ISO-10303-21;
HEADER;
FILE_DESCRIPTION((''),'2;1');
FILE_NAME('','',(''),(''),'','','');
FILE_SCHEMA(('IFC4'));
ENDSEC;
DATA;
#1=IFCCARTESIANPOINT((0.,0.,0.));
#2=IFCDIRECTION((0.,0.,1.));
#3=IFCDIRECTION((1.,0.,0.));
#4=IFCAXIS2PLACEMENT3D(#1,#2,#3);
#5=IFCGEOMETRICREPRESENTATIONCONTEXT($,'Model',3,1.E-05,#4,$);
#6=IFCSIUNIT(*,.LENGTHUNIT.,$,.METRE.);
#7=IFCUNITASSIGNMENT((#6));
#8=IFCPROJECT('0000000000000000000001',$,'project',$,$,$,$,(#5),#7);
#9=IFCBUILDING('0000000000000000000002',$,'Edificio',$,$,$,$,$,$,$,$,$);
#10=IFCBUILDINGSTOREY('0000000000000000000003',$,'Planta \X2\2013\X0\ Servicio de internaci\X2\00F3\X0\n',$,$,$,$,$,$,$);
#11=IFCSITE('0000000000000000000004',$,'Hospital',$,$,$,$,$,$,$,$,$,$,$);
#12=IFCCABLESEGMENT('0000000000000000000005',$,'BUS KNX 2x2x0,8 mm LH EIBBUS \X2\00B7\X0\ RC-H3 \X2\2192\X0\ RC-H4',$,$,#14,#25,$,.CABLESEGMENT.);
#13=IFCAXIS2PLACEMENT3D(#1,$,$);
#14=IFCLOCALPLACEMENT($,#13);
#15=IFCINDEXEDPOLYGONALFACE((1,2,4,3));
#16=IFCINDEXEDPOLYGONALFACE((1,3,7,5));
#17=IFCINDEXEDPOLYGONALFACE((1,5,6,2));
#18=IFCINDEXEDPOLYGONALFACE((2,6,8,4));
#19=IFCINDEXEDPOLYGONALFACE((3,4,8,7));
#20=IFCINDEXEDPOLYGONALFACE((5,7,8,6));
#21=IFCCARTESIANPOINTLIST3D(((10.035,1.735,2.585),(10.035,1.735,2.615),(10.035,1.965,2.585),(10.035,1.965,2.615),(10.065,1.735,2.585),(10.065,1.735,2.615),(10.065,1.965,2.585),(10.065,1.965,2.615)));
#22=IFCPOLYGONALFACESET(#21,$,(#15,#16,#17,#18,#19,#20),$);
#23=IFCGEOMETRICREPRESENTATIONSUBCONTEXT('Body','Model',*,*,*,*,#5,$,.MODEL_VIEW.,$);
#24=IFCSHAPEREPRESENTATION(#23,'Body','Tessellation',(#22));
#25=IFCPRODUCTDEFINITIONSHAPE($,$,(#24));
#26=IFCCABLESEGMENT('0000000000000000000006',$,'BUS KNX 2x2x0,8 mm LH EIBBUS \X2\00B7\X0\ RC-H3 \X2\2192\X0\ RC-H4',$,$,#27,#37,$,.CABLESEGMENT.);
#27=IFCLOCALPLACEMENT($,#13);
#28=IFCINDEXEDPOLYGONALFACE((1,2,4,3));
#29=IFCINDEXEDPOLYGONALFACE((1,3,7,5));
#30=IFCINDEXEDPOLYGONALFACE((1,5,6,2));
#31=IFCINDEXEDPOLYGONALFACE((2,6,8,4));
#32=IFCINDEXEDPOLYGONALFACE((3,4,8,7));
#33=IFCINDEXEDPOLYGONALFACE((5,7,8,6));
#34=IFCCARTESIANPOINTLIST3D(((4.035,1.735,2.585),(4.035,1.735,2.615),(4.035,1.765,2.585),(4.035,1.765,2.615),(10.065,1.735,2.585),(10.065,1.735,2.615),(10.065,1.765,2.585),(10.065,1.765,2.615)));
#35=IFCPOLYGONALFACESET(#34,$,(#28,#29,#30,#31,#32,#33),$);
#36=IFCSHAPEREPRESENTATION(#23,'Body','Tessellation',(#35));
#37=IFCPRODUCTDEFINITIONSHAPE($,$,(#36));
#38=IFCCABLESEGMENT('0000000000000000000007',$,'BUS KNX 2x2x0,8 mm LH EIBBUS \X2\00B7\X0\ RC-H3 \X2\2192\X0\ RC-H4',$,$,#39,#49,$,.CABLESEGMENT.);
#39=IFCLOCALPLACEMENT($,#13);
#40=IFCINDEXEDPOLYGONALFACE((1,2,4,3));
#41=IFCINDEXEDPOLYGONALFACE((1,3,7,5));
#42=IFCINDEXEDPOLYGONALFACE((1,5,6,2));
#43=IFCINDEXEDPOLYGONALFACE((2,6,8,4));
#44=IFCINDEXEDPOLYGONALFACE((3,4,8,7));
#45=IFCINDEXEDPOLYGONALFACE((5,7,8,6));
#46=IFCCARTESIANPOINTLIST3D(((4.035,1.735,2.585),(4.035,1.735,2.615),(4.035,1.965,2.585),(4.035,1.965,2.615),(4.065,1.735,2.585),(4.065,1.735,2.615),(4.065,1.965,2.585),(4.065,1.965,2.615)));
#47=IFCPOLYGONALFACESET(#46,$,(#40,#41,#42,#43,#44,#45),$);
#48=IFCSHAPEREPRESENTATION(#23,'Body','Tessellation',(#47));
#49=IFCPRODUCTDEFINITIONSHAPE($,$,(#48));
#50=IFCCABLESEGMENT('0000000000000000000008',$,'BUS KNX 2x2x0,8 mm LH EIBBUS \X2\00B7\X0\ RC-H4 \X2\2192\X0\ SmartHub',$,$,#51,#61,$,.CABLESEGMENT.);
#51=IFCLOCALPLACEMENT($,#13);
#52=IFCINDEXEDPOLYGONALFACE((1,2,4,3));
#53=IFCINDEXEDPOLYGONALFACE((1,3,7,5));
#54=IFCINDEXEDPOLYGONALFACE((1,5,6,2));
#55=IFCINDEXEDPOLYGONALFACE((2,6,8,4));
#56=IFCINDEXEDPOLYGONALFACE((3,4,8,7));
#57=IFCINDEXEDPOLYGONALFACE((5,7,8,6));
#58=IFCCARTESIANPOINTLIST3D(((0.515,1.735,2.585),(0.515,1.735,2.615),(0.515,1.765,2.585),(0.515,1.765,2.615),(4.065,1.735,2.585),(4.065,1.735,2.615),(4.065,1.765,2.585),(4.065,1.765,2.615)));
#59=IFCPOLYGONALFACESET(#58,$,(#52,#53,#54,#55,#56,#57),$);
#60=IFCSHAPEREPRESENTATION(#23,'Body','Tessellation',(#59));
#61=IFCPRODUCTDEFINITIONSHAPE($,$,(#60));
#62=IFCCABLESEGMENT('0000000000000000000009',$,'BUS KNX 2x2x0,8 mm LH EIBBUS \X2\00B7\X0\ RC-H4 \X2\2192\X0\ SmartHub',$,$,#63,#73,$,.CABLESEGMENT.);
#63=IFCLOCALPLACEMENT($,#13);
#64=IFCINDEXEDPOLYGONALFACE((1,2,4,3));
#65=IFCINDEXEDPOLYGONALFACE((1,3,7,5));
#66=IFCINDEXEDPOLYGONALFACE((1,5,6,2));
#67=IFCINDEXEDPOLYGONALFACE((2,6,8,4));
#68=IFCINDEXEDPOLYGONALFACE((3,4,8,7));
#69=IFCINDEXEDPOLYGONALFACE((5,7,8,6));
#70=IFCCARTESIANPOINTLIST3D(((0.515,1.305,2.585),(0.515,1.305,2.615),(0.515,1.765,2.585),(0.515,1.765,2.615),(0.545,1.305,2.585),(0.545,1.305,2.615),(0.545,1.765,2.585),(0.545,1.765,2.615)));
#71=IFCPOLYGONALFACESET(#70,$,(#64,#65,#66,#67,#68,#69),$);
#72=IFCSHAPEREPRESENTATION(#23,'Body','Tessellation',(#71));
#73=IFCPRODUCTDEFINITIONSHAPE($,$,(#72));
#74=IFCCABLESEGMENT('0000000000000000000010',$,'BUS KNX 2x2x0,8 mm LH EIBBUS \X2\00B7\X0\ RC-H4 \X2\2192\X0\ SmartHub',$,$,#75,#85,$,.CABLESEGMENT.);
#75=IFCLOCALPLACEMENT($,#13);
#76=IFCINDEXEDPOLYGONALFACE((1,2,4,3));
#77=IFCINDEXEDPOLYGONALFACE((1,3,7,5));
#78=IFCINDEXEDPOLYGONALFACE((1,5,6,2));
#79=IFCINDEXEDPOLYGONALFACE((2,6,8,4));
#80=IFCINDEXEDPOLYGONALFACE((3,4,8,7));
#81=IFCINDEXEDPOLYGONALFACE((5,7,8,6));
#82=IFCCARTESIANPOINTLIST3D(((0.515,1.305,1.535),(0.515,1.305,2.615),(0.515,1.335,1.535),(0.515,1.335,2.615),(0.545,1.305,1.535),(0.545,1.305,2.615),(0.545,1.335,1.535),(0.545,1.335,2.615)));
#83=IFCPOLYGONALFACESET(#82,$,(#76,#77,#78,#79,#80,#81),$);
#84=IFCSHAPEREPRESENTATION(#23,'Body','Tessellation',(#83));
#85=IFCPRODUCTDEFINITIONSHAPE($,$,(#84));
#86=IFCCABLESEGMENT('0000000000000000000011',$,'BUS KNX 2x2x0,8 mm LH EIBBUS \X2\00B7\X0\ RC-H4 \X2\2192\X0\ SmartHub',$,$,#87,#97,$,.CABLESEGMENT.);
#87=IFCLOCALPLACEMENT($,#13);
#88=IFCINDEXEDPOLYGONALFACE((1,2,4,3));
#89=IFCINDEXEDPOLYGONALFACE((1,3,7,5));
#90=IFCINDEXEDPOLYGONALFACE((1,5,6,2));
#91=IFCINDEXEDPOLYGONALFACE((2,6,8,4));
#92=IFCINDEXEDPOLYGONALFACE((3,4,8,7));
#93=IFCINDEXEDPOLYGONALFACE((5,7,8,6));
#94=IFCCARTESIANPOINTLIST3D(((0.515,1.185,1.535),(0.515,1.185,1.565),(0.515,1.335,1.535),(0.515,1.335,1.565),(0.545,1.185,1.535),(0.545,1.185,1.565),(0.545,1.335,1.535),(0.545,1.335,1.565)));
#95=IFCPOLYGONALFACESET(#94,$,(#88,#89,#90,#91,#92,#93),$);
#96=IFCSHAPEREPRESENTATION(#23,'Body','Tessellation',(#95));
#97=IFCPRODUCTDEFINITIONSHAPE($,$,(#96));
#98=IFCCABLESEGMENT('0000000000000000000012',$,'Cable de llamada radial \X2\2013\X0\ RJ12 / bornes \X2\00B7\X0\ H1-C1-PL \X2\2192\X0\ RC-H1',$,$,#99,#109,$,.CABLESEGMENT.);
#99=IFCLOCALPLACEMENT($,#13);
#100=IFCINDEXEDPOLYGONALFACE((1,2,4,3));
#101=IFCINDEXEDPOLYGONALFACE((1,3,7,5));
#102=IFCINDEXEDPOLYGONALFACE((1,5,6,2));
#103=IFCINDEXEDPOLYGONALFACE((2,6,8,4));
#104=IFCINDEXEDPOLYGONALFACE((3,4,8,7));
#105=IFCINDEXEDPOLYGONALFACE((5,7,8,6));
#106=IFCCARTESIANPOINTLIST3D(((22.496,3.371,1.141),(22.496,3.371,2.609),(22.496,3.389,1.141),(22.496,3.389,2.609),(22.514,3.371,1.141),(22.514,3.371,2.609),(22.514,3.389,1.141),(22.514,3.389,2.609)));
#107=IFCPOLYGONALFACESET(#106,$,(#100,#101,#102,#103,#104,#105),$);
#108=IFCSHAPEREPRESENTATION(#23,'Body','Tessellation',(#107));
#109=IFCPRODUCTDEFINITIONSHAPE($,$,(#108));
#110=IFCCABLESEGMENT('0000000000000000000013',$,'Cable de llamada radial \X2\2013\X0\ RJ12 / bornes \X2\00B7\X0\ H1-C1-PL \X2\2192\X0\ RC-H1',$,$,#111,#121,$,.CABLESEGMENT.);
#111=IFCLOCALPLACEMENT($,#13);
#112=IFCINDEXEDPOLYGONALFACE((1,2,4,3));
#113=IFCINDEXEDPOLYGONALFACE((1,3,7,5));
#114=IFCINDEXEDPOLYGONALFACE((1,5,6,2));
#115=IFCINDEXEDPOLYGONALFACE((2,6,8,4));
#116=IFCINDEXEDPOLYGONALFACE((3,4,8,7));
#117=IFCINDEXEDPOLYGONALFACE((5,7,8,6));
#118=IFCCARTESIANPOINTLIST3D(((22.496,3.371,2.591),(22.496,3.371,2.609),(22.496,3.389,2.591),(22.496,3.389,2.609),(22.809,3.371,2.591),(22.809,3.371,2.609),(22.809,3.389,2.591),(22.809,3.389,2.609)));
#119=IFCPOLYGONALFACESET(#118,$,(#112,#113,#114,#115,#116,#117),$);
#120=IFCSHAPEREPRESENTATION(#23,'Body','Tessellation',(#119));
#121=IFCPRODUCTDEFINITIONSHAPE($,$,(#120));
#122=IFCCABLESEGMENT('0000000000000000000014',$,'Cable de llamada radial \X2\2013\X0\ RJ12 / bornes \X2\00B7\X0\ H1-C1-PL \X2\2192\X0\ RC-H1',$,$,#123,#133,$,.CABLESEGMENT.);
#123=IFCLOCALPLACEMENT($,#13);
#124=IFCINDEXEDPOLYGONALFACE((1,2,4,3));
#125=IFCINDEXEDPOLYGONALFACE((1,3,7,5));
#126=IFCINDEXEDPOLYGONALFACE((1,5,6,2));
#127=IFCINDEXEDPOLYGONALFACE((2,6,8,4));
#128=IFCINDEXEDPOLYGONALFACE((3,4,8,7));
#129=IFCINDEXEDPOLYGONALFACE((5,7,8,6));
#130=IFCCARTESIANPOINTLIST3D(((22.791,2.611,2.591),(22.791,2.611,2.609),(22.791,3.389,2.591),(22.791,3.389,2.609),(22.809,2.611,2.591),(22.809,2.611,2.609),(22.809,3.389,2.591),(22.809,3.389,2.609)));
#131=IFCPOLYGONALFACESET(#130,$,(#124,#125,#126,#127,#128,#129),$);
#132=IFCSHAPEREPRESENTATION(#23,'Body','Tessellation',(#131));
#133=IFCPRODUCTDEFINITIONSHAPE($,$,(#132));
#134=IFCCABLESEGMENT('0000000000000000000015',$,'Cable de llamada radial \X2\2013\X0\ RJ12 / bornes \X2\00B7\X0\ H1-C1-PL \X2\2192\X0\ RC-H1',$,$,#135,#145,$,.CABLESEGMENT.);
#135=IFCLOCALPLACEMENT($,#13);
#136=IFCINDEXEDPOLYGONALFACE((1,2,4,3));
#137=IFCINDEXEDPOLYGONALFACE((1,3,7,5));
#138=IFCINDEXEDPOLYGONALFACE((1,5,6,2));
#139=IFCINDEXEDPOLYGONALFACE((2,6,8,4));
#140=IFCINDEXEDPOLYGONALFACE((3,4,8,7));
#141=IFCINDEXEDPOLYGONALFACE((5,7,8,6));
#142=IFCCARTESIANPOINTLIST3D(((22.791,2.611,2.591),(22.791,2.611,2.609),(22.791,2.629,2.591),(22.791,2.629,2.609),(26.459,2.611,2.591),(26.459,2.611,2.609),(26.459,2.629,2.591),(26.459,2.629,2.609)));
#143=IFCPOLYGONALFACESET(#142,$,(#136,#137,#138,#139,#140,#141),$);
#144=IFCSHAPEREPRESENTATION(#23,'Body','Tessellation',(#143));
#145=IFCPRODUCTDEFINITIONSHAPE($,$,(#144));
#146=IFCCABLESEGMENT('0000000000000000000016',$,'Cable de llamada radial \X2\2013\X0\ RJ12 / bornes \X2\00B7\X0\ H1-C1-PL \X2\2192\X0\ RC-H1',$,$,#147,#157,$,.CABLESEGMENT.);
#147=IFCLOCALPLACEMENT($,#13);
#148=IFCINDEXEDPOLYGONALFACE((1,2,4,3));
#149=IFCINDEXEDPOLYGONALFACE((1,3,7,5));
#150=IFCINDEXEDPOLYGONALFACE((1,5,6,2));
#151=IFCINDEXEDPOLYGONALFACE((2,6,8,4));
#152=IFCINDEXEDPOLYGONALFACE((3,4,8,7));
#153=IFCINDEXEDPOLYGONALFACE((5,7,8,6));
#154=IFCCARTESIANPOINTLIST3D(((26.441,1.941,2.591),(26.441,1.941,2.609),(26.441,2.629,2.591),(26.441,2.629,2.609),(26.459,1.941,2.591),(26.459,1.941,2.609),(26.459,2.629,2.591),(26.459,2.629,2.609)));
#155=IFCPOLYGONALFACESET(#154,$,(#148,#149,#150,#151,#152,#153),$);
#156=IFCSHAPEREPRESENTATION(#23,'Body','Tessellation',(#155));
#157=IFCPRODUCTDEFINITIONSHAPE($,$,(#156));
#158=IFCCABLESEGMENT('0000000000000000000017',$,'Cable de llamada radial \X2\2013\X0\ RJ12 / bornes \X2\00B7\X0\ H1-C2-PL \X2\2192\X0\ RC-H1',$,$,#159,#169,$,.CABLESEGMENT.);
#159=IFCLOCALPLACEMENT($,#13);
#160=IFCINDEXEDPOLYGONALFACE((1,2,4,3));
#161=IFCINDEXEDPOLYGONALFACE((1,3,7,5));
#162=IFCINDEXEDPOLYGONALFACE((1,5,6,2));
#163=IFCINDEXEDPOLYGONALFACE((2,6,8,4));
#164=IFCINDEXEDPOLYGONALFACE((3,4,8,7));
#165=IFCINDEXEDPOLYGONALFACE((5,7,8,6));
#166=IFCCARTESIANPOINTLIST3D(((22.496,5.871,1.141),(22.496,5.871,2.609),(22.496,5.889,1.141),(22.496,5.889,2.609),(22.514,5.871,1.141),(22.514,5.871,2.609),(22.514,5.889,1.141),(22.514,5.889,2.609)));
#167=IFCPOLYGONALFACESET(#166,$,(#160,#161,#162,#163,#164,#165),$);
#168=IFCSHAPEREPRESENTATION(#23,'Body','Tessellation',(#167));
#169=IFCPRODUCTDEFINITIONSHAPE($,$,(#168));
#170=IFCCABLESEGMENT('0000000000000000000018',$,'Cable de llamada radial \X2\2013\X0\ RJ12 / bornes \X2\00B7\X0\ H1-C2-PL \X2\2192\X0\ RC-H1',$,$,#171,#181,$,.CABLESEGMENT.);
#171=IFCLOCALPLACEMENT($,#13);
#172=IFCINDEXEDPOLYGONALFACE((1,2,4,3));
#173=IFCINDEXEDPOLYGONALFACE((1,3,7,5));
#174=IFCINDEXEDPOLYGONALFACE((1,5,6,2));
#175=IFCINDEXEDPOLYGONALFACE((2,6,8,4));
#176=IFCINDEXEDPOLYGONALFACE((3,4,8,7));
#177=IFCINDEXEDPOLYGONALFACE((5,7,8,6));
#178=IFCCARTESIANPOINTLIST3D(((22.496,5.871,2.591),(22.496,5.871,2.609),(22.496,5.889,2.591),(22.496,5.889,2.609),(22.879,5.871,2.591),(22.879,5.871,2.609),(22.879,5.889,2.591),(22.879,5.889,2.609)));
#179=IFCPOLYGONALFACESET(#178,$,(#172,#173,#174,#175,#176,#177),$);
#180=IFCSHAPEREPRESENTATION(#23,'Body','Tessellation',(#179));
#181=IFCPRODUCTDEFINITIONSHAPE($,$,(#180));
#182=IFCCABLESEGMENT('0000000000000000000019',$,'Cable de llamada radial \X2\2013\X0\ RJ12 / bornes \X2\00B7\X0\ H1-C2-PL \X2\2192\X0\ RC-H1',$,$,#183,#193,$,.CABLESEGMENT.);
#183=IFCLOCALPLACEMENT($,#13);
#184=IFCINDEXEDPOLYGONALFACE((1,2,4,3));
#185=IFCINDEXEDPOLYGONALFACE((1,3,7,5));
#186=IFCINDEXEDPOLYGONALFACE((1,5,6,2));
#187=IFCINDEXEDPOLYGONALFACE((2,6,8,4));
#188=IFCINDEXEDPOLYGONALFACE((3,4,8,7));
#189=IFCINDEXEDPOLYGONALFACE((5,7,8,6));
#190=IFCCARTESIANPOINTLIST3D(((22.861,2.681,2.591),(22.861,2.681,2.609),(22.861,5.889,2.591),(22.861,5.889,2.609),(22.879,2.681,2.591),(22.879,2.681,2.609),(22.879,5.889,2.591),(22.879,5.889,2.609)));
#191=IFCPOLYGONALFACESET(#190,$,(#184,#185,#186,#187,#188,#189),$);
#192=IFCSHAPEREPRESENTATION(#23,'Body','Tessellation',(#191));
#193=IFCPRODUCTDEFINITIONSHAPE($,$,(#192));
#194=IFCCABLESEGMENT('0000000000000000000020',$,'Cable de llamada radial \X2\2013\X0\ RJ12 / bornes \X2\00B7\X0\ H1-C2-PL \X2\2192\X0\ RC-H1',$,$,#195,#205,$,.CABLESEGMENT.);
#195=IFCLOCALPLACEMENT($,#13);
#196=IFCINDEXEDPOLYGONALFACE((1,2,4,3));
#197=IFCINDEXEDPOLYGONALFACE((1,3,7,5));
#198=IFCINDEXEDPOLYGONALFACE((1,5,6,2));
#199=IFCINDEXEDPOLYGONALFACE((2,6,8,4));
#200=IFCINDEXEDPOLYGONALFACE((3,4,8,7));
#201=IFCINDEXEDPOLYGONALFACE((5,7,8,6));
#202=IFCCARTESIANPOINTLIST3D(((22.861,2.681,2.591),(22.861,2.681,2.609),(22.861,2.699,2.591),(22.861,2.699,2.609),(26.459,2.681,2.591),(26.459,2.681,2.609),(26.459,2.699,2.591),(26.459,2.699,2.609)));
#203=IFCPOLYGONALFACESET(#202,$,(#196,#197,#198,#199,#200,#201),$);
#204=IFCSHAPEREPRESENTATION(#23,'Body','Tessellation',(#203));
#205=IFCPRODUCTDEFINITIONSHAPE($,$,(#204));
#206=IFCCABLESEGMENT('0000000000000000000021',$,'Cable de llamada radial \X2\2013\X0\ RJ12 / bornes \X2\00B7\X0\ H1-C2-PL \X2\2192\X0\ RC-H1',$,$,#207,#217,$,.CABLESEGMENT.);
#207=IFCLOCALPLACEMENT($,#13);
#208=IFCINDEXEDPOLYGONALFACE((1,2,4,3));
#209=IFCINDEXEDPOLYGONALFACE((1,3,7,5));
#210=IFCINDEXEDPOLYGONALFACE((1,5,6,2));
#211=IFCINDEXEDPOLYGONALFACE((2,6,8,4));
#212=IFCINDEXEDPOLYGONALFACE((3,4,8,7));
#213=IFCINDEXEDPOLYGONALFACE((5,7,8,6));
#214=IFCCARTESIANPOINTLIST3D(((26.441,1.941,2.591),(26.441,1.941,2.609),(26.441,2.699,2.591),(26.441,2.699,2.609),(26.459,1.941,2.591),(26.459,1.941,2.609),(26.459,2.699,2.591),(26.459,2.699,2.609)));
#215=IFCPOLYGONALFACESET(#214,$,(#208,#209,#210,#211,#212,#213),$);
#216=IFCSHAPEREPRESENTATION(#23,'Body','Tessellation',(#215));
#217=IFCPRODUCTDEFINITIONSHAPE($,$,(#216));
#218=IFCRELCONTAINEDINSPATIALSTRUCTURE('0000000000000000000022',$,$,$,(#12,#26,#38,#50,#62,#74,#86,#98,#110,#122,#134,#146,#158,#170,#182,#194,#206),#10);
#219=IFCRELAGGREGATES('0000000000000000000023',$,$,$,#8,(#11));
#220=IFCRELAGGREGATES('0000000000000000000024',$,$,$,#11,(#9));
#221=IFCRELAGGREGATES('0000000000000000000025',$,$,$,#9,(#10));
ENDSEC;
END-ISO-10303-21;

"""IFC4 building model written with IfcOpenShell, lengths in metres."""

from ifc_helpers import new_model, si_unit, frame, origin_with_axes, context, subcontext, project, spatial, line, indexed_curve, outline, extrude, element, save


model = new_model("IFC4")

# Units and contexts
model_context = context("Model", 3, precision=1e-05, world=origin_with_axes())
body_context = subcontext(model_context, "Body", "Model", "MODEL_VIEW")
ifc_project = project(units=[si_unit("LENGTHUNIT", "METRE")], contexts=[model_context])

# Site, building, storey
site = spatial("IfcSite", under=ifc_project, Name="Hospital")
building = spatial("IfcBuilding", under=site, Name="Edificio")
storey = spatial("IfcBuildingStorey", under=building, Name="Planta – Servicio de internación")

# Cable segments
element("IfcCableSegment", 1, inside=storey, Name="BUS KNX 2x2x0,8 mm LH EIBBUS · RC-H3 → RC-H4", PredefinedType="CABLESEGMENT", context=body_context, shape_type="SweptSolid", body=[
    extrude(outline(indexed_curve([(0.0, 0.0), (0.03, 0.0), (0.03, 0.23), (0.0, 0.23)], segments=[line(1, 2, 3, 4, 1)])), frame((10.035, 1.735, 2.585), z_axis=(0.0, 0.0, 1.0), x_axis=(1.0, 0.0, 0.0)), (0.0, 0.0, 1.0), 0.03),
])
element("IfcCableSegment", 2, inside=storey, Name="BUS KNX 2x2x0,8 mm LH EIBBUS · RC-H3 → RC-H4", PredefinedType="CABLESEGMENT", context=body_context, shape_type="SweptSolid", body=[
    extrude(outline(indexed_curve([(0.0, 0.0), (6.03, 0.0), (6.03, 0.03), (0.0, 0.03)], segments=[line(1, 2, 3, 4, 1)])), frame((4.035, 1.735, 2.585), z_axis=(0.0, 0.0, 1.0), x_axis=(1.0, 0.0, 0.0)), (0.0, 0.0, 1.0), 0.03),
])
element("IfcCableSegment", 3, inside=storey, Name="BUS KNX 2x2x0,8 mm LH EIBBUS · RC-H3 → RC-H4", PredefinedType="CABLESEGMENT", context=body_context, shape_type="SweptSolid", body=[
    extrude(outline(indexed_curve([(0.0, 0.0), (0.03, 0.0), (0.03, 0.23), (0.0, 0.23)], segments=[line(1, 2, 3, 4, 1)])), frame((4.035, 1.735, 2.585), z_axis=(0.0, 0.0, 1.0), x_axis=(1.0, 0.0, 0.0)), (0.0, 0.0, 1.0), 0.03),
])
element("IfcCableSegment", 4, inside=storey, Name="BUS KNX 2x2x0,8 mm LH EIBBUS · RC-H4 → SmartHub", PredefinedType="CABLESEGMENT", context=body_context, shape_type="SweptSolid", body=[
    extrude(outline(indexed_curve([(0.0, 0.0), (3.55, 0.0), (3.55, 0.03), (0.0, 0.03)], segments=[line(1, 2, 3, 4, 1)])), frame((0.515, 1.735, 2.585), z_axis=(0.0, 0.0, 1.0), x_axis=(1.0, 0.0, 0.0)), (0.0, 0.0, 1.0), 0.03),
])
element("IfcCableSegment", 5, inside=storey, Name="BUS KNX 2x2x0,8 mm LH EIBBUS · RC-H4 → SmartHub", PredefinedType="CABLESEGMENT", context=body_context, shape_type="SweptSolid", body=[
    extrude(outline(indexed_curve([(0.0, 0.0), (0.03, 0.0), (0.03, 0.46), (0.0, 0.46)], segments=[line(1, 2, 3, 4, 1)])), frame((0.515, 1.305, 2.585), z_axis=(0.0, 0.0, 1.0), x_axis=(1.0, 0.0, 0.0)), (0.0, 0.0, 1.0), 0.03),
])
element("IfcCableSegment", 6, inside=storey, Name="BUS KNX 2x2x0,8 mm LH EIBBUS · RC-H4 → SmartHub", PredefinedType="CABLESEGMENT", context=body_context, shape_type="SweptSolid", body=[
    extrude(outline(indexed_curve([(0.0, 0.0), (0.03, 0.0), (0.03, 0.03), (0.0, 0.03)], segments=[line(1, 2, 3, 4, 1)])), frame((0.515, 1.305, 1.535), z_axis=(0.0, 0.0, 1.0), x_axis=(1.0, 0.0, 0.0)), (0.0, 0.0, 1.0), 1.08),
])
element("IfcCableSegment", 7, inside=storey, Name="BUS KNX 2x2x0,8 mm LH EIBBUS · RC-H4 → SmartHub", PredefinedType="CABLESEGMENT", context=body_context, shape_type="SweptSolid", body=[
    extrude(outline(indexed_curve([(0.0, 0.0), (0.03, 0.0), (0.03, 0.15), (0.0, 0.15)], segments=[line(1, 2, 3, 4, 1)])), frame((0.515, 1.185, 1.535), z_axis=(0.0, 0.0, 1.0), x_axis=(1.0, 0.0, 0.0)), (0.0, 0.0, 1.0), 0.03),
])
element("IfcCableSegment", 8, inside=storey, Name="Cable de llamada radial – RJ12 / bornes · H1-C1-PL → RC-H1", PredefinedType="CABLESEGMENT", context=body_context, shape_type="SweptSolid", body=[
    extrude(outline(indexed_curve([(0.0, 0.0), (0.018, 0.0), (0.018, 0.018), (0.0, 0.018)], segments=[line(1, 2, 3, 4, 1)])), frame((22.496, 3.371, 1.141), z_axis=(0.0, 0.0, 1.0), x_axis=(1.0, 0.0, 0.0)), (0.0, 0.0, 1.0), 1.468),
])
element("IfcCableSegment", 9, inside=storey, Name="Cable de llamada radial – RJ12 / bornes · H1-C1-PL → RC-H1", PredefinedType="CABLESEGMENT", context=body_context, shape_type="SweptSolid", body=[
    extrude(outline(indexed_curve([(0.0, 0.0), (0.313, 0.0), (0.313, 0.018), (0.0, 0.018)], segments=[line(1, 2, 3, 4, 1)])), frame((22.496, 3.371, 2.591), z_axis=(0.0, 0.0, 1.0), x_axis=(1.0, 0.0, 0.0)), (0.0, 0.0, 1.0), 0.018),
])
element("IfcCableSegment", 10, inside=storey, Name="Cable de llamada radial – RJ12 / bornes · H1-C1-PL → RC-H1", PredefinedType="CABLESEGMENT", context=body_context, shape_type="SweptSolid", body=[
    extrude(outline(indexed_curve([(0.0, 0.0), (0.018, 0.0), (0.018, 0.778), (0.0, 0.778)], segments=[line(1, 2, 3, 4, 1)])), frame((22.791, 2.611, 2.591), z_axis=(0.0, 0.0, 1.0), x_axis=(1.0, 0.0, 0.0)), (0.0, 0.0, 1.0), 0.018),
])
element("IfcCableSegment", 11, inside=storey, Name="Cable de llamada radial – RJ12 / bornes · H1-C1-PL → RC-H1", PredefinedType="CABLESEGMENT", context=body_context, shape_type="SweptSolid", body=[
    extrude(outline(indexed_curve([(0.0, 0.0), (3.668, 0.0), (3.668, 0.018), (0.0, 0.018)], segments=[line(1, 2, 3, 4, 1)])), frame((22.791, 2.611, 2.591), z_axis=(0.0, 0.0, 1.0), x_axis=(1.0, 0.0, 0.0)), (0.0, 0.0, 1.0), 0.018),
])
element("IfcCableSegment", 12, inside=storey, Name="Cable de llamada radial – RJ12 / bornes · H1-C1-PL → RC-H1", PredefinedType="CABLESEGMENT", context=body_context, shape_type="SweptSolid", body=[
    extrude(outline(indexed_curve([(0.0, 0.0), (0.018, 0.0), (0.018, 0.688), (0.0, 0.688)], segments=[line(1, 2, 3, 4, 1)])), frame((26.441, 1.941, 2.591), z_axis=(0.0, 0.0, 1.0), x_axis=(1.0, 0.0, 0.0)), (0.0, 0.0, 1.0), 0.018),
])
element("IfcCableSegment", 13, inside=storey, Name="Cable de llamada radial – RJ12 / bornes · H1-C2-PL → RC-H1", PredefinedType="CABLESEGMENT", context=body_context, shape_type="SweptSolid", body=[
    extrude(outline(indexed_curve([(0.0, 0.0), (0.018, 0.0), (0.018, 0.018), (0.0, 0.018)], segments=[line(1, 2, 3, 4, 1)])), frame((22.496, 5.871, 1.141), z_axis=(0.0, 0.0, 1.0), x_axis=(1.0, 0.0, 0.0)), (0.0, 0.0, 1.0), 1.468),
])
element("IfcCableSegment", 14, inside=storey, Name="Cable de llamada radial – RJ12 / bornes · H1-C2-PL → RC-H1", PredefinedType="CABLESEGMENT", context=body_context, shape_type="SweptSolid", body=[
    extrude(outline(indexed_curve([(0.0, 0.0), (0.383, 0.0), (0.383, 0.018), (0.0, 0.018)], segments=[line(1, 2, 3, 4, 1)])), frame((22.496, 5.871, 2.591), z_axis=(0.0, 0.0, 1.0), x_axis=(1.0, 0.0, 0.0)), (0.0, 0.0, 1.0), 0.018),
])
element("IfcCableSegment", 15, inside=storey, Name="Cable de llamada radial – RJ12 / bornes · H1-C2-PL → RC-H1", PredefinedType="CABLESEGMENT", context=body_context, shape_type="SweptSolid", body=[
    extrude(outline(indexed_curve([(0.0, 0.0), (0.018, 0.0), (0.018, 3.208), (0.0, 3.208)], segments=[line(1, 2, 3, 4, 1)])), frame((22.861, 2.681, 2.591), z_axis=(0.0, 0.0, 1.0), x_axis=(1.0, 0.0, 0.0)), (0.0, 0.0, 1.0), 0.018),
])
element("IfcCableSegment", 16, inside=storey, Name="Cable de llamada radial – RJ12 / bornes · H1-C2-PL → RC-H1", PredefinedType="CABLESEGMENT", context=body_context, shape_type="SweptSolid", body=[
    extrude(outline(indexed_curve([(0.0, 0.0), (3.598, 0.0), (3.598, 0.018), (0.0, 0.018)], segments=[line(1, 2, 3, 4, 1)])), frame((22.861, 2.681, 2.591), z_axis=(0.0, 0.0, 1.0), x_axis=(1.0, 0.0, 0.0)), (0.0, 0.0, 1.0), 0.018),
])
element("IfcCableSegment", 17, inside=storey, Name="Cable de llamada radial – RJ12 / bornes · H1-C2-PL → RC-H1", PredefinedType="CABLESEGMENT", context=body_context, shape_type="SweptSolid", body=[
    extrude(outline(indexed_curve([(0.0, 0.0), (0.018, 0.0), (0.018, 0.758), (0.0, 0.758)], segments=[line(1, 2, 3, 4, 1)])), frame((26.441, 1.941, 2.591), z_axis=(0.0, 0.0, 1.0), x_axis=(1.0, 0.0, 0.0)), (0.0, 0.0, 1.0), 0.018),
])

save(model, "model.ifc")
